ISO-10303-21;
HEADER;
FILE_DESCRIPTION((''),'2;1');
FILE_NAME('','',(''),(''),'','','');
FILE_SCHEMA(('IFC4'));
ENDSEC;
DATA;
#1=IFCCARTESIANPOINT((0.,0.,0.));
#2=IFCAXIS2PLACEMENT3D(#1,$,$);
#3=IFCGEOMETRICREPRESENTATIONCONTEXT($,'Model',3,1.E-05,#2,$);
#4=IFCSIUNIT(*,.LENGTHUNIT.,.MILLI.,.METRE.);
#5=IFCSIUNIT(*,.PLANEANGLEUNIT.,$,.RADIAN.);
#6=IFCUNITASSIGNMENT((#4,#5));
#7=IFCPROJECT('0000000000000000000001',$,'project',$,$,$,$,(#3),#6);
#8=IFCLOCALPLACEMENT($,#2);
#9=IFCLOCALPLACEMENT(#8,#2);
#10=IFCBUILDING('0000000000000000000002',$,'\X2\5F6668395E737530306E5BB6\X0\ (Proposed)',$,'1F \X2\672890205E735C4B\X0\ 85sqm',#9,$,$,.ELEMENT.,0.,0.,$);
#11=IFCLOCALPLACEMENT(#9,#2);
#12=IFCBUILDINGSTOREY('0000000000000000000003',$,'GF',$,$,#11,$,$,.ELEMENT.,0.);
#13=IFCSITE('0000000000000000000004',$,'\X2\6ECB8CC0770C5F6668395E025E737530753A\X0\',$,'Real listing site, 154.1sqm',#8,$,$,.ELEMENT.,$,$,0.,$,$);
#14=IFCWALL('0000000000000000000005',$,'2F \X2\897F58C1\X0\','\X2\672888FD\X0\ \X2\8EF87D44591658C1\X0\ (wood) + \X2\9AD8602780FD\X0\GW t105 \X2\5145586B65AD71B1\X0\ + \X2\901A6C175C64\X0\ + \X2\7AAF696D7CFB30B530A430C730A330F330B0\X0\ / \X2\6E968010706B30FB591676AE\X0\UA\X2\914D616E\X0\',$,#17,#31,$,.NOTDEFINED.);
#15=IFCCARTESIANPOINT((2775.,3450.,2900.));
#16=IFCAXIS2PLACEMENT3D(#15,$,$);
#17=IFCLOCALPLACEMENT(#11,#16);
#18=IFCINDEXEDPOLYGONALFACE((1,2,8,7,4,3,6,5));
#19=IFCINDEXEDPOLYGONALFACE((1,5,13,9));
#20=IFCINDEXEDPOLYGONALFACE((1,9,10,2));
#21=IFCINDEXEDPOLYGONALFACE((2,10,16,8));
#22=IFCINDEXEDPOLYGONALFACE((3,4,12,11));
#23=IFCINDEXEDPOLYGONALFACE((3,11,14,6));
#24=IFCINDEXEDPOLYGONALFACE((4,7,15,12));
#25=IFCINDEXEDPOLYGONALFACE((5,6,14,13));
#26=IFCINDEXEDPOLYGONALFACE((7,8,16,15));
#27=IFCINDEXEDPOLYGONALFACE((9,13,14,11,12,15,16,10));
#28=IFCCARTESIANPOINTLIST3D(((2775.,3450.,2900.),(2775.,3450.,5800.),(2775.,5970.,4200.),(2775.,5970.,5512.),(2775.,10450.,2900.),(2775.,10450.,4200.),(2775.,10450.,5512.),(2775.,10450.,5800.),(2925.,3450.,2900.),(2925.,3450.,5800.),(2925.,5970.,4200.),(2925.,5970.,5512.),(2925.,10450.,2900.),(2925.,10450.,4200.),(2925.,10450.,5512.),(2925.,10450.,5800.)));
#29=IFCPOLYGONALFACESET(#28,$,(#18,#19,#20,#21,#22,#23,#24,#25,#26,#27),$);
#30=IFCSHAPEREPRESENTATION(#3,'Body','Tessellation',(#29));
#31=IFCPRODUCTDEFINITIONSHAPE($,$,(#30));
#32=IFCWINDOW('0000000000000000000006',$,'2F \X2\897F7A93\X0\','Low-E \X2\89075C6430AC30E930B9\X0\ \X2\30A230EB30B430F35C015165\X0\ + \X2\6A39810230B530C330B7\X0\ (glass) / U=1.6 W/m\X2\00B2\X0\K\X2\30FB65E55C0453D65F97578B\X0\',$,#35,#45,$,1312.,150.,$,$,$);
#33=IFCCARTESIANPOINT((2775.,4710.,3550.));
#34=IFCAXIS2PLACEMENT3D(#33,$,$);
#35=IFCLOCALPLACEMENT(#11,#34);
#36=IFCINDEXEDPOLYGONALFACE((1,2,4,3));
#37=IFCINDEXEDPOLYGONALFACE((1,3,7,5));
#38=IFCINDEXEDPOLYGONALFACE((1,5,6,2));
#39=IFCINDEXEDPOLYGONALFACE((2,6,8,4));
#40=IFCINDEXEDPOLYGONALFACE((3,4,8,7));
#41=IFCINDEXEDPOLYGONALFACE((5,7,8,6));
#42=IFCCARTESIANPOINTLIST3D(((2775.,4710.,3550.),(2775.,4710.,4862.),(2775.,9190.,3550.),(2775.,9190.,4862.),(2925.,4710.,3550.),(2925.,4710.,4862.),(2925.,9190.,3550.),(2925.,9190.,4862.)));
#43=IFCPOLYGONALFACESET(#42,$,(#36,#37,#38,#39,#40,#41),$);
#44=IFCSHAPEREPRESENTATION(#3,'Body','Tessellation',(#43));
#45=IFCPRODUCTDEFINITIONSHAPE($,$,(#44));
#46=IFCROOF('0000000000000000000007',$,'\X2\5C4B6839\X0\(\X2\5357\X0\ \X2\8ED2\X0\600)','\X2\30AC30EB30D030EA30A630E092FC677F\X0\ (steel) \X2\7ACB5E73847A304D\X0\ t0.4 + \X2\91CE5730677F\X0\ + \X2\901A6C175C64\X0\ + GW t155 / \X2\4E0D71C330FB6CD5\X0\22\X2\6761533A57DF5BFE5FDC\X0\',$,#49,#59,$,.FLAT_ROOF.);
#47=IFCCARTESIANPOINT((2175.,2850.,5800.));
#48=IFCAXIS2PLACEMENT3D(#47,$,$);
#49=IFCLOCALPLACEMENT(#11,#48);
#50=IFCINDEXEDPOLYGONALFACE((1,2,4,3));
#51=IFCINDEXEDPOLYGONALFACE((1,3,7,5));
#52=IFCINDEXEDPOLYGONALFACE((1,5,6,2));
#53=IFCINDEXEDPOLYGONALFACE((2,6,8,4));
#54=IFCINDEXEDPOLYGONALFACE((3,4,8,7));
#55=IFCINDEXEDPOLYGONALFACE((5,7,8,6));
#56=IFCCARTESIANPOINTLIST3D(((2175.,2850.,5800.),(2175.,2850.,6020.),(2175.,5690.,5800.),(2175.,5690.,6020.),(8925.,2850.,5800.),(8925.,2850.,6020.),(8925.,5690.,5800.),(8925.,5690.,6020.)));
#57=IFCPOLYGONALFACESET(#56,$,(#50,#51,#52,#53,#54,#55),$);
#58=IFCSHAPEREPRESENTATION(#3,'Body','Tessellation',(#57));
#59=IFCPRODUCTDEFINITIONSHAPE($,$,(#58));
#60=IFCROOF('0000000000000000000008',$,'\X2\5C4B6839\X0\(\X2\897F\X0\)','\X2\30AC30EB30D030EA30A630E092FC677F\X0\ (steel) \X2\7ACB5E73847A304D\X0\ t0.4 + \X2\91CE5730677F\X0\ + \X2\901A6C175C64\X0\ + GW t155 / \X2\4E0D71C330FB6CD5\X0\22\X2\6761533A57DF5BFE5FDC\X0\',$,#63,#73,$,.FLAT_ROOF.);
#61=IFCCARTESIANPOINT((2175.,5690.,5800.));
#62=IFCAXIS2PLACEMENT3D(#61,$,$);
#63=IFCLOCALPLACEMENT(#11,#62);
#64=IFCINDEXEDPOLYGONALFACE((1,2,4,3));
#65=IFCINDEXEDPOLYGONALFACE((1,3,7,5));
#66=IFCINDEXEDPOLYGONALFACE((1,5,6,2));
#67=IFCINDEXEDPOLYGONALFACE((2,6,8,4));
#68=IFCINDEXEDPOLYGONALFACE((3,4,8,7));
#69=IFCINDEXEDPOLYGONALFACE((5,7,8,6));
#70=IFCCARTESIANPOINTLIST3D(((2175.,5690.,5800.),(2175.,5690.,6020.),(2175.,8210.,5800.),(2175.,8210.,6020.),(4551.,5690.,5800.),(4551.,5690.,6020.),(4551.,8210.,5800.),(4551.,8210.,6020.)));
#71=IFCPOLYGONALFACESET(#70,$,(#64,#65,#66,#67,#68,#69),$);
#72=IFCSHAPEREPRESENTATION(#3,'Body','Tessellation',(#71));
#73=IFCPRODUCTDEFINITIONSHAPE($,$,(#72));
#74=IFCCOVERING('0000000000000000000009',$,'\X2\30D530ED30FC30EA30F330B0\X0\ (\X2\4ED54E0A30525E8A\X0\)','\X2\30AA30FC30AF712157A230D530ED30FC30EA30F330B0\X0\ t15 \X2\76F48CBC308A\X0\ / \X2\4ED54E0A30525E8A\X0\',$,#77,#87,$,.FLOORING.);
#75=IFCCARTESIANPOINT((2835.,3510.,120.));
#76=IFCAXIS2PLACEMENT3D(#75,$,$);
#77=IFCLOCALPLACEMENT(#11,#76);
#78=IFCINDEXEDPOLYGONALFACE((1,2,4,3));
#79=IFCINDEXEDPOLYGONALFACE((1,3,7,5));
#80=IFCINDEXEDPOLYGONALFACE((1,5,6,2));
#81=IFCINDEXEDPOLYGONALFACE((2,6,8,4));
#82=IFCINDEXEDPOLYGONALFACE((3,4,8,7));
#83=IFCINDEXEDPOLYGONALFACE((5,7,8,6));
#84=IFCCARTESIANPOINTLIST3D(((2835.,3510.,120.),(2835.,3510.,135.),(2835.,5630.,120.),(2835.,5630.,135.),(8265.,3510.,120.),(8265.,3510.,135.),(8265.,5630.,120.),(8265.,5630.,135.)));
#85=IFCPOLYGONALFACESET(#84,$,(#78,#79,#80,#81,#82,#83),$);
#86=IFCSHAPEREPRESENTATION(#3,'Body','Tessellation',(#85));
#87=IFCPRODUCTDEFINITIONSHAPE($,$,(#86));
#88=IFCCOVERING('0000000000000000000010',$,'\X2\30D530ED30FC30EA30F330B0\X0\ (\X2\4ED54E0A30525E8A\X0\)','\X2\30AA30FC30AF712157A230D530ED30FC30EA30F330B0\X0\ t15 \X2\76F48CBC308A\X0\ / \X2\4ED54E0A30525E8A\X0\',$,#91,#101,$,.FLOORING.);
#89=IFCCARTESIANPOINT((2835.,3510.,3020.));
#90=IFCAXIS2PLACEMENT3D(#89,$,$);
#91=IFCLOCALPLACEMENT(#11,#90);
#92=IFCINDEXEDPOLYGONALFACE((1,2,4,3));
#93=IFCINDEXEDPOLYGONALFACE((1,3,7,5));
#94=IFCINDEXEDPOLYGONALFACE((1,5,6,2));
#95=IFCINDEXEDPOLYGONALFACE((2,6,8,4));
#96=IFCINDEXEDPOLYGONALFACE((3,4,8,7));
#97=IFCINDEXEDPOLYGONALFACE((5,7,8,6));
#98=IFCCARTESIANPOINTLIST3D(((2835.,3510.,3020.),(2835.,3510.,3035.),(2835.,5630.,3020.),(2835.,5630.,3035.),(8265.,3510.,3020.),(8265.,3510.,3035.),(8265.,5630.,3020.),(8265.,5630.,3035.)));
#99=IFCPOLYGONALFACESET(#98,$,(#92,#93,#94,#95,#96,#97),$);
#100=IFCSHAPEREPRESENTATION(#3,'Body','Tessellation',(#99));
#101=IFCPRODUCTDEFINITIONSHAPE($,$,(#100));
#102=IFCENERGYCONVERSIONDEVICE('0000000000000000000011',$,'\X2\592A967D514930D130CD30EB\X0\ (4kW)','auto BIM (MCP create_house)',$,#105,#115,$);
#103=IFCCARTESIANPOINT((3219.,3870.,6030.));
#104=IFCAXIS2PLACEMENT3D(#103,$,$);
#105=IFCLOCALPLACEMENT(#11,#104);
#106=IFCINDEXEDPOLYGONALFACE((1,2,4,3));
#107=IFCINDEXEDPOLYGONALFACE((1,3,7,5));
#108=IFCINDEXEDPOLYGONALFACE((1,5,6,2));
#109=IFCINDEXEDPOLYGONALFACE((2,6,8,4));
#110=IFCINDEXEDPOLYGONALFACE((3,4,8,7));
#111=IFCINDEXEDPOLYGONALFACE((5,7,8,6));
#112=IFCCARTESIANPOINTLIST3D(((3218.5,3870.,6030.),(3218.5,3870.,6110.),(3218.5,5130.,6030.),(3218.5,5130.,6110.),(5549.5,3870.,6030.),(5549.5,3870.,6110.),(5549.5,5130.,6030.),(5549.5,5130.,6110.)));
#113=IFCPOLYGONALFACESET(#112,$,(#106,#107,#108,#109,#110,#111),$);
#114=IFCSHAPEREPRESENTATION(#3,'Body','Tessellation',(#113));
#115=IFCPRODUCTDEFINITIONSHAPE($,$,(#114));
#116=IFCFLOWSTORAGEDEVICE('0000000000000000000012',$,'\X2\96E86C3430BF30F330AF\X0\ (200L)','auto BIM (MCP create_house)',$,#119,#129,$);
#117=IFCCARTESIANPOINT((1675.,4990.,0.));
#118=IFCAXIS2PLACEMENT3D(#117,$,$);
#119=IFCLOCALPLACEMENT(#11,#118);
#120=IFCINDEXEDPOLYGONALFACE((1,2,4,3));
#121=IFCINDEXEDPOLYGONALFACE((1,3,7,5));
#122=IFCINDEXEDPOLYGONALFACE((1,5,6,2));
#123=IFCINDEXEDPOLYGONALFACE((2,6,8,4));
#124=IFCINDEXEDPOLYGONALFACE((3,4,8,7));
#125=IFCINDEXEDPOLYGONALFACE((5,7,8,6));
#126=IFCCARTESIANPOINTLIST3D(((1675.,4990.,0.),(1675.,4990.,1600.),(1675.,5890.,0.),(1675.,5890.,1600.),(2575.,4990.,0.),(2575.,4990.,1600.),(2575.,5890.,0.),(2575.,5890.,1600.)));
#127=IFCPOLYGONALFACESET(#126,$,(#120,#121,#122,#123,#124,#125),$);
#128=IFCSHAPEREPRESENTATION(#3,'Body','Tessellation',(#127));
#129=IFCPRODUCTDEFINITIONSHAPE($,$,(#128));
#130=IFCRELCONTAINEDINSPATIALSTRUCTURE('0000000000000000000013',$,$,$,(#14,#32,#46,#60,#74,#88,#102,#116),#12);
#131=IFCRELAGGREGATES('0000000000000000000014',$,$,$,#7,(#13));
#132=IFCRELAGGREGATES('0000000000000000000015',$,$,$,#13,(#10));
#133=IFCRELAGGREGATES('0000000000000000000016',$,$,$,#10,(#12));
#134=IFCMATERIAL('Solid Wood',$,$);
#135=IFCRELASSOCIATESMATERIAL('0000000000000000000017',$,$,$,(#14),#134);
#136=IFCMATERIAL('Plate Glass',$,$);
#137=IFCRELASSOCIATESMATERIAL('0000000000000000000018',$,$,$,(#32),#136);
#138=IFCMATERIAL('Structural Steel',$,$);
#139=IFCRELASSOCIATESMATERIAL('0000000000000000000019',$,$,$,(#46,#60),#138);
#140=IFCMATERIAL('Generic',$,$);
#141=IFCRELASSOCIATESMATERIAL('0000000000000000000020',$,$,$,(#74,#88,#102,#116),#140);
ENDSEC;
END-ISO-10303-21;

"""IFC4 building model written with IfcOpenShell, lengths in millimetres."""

from ifc_helpers import new_model, si_unit, frame, frame_2d, origin, place, context, project, spatial, rectangle, extrude, material, element, fill, save


model = new_model("IFC4")

# Units and contexts
model_context = context("Model", 3, precision=1e-05, world=origin())
ifc_project = project(units=[si_unit("LENGTHUNIT", "METRE", prefix="MILLI"), si_unit("PLANEANGLEUNIT", "RADIAN")], contexts=[model_context])

# Site, building, storey
site_placement = place(None, origin())
site = spatial("IfcSite", under=ifc_project, at=site_placement, Name="滋賀県彦根市平田町", ObjectType="Real listing site, 154.1sqm", CompositionType="ELEMENT", RefElevation=0.0)
building_placement = place(site_placement, origin())
building = spatial("IfcBuilding", under=site, at=building_placement, Name="彦根平田の家 (Proposed)", ObjectType="1F 木造平屋 85sqm", CompositionType="ELEMENT", ElevationOfRefHeight=0.0, ElevationOfTerrain=0.0)
storey_placement = place(building_placement, origin())
storey = spatial("IfcBuildingStorey", under=building, at=storey_placement, Name="GF", CompositionType="ELEMENT", Elevation=0.0)

# Shared definitions
ifc_material_1 = material(Name="Solid Wood")
ifc_material_2 = material(Name="Generic")

# Shared definitions
ifc_material_3 = material(Name="Plate Glass")

# Wall, opening, window
wall_1_placement = place(storey_placement, frame((2775.0, 3450.0, 2900.0)))
wall_1 = element("IfcWall", 1, at=wall_1_placement, inside=storey, material=ifc_material_1, Name="2F 西壁", Description="木製 軸組外壁 (wood) + 高性能GW t105 充填断熱 + 通気層 + 窯業系サイディング / 準耐火・外皮UA配慮", PredefinedType="NOTDEFINED", context=model_context, shape_type="SweptSolid", body=[
    extrude(rectangle(XDim=150.0, YDim=7000.0, at=frame_2d((75.0, 3500.0))), frame((2775.0, 3450.0, 2900.0)), (0.0, 0.0, 1.0), 2900.0),
])
opening_1_placement = place(storey_placement, frame((2775.0, 4710.0, 3550.0)))
opening_1 = element("IfcOpeningElement", 2, at=opening_1_placement, cuts=wall_1, PredefinedType="NOTDEFINED", context=model_context, shape_type="SweptSolid", body=[
    extrude(rectangle(XDim=150.0, YDim=4480.0, at=frame_2d((75.0, 2240.0))), frame((2775.0, 4710.0, 3550.0)), (0.0, 0.0, 1.0), 1312.0),
])
window_1_placement = place(storey_placement, frame((2775.0, 4710.0, 3550.0)))
window_1 = element("IfcWindow", 3, at=window_1_placement, inside=storey, material=ifc_material_3, Name="2F 西窓", Description="Low-E 複層ガラス アルゴン封入 + 樹脂サッシ (glass) / U=1.6 W/m²K・日射取得型", OverallHeight=1312.0, OverallWidth=150.0, context=model_context, shape_type="SweptSolid", body=[
    extrude(rectangle(XDim=150.0, YDim=4480.0, at=frame_2d((75.0, 2240.0))), frame((2775.0, 4710.0, 3550.0)), (0.0, 0.0, 1.0), 1312.0),
])
fill(opening_1, window_1)

# Roofs
ifc_material_4 = material(Name="Structural Steel")
roof_1_placement = place(storey_placement, frame((2175.0, 2850.0, 5800.0)))
element("IfcRoof", 4, at=roof_1_placement, inside=storey, material=ifc_material_4, Name="屋根(南 軒600)", Description="ガルバリウム鋼板 (steel) 立平葺き t0.4 + 野地板 + 通気層 + GW t155 / 不燃・法22条区域対応", PredefinedType="FLAT_ROOF", context=model_context, shape_type="SweptSolid", body=[
    extrude(rectangle(XDim=6750.0, YDim=2840.0, at=frame_2d((3375.0, 1420.0))), frame((2175.0, 2850.0, 5800.0)), (0.0, 0.0, 1.0), 220.0),
])
roof_2_placement = place(storey_placement, frame((2175.0, 5690.0, 5800.0)))
element("IfcRoof", 5, at=roof_2_placement, inside=storey, material=ifc_material_4, Name="屋根(西)", Description="ガルバリウム鋼板 (steel) 立平葺き t0.4 + 野地板 + 通気層 + GW t155 / 不燃・法22条区域対応", PredefinedType="FLAT_ROOF", context=model_context, shape_type="SweptSolid", body=[
    extrude(rectangle(XDim=2376.0, YDim=2520.0, at=frame_2d((1188.0, 1260.0))), frame((2175.0, 5690.0, 5800.0)), (0.0, 0.0, 1.0), 220.0),
])

# Coverings
covering_1_placement = place(storey_placement, frame((2835.0, 3510.0, 120.0)))
element("IfcCovering", 6, at=covering_1_placement, inside=storey, material=ifc_material_2, Name="フローリング (仕上げ床)", Description="オーク無垢フローリング t15 直貼り / 仕上げ床", PredefinedType="FLOORING", context=model_context, shape_type="SweptSolid", body=[
    extrude(rectangle(XDim=5430.0, YDim=2120.0, at=frame_2d((2715.0, 1060.0))), frame((2835.0, 3510.0, 120.0)), (0.0, 0.0, 1.0), 15.0),
])
covering_2_placement = place(storey_placement, frame((2835.0, 3510.0, 3020.0)))
element("IfcCovering", 7, at=covering_2_placement, inside=storey, material=ifc_material_2, Name="フローリング (仕上げ床)", Description="オーク無垢フローリング t15 直貼り / 仕上げ床", PredefinedType="FLOORING", context=model_context, shape_type="SweptSolid", body=[
    extrude(rectangle(XDim=5430.0, YDim=2120.0, at=frame_2d((2715.0, 1060.0))), frame((2835.0, 3510.0, 3020.0)), (0.0, 0.0, 1.0), 15.0),
])

# Energy conversion device
energy_conversion_device_placement = place(storey_placement, frame((3219.0, 3870.0, 6030.0)))
element("IfcEnergyConversionDevice", 8, at=energy_conversion_device_placement, inside=storey, material=ifc_material_2, Name="太陽光パネル (4kW)", Description="auto BIM (MCP create_house)", context=model_context, shape_type="SweptSolid", body=[
    extrude(rectangle(XDim=2331.0, YDim=1260.0, at=frame_2d((1165.0, 630.0))), frame((3219.0, 3870.0, 6030.0)), (0.0, 0.0, 1.0), 80.0),
])

# Flow storage device
flow_storage_device_placement = place(storey_placement, frame((1675.0, 4990.0, 0.0)))
element("IfcFlowStorageDevice", 9, at=flow_storage_device_placement, inside=storey, material=ifc_material_2, Name="雨水タンク (200L)", Description="auto BIM (MCP create_house)", context=model_context, shape_type="SweptSolid", body=[
    extrude(rectangle(XDim=900.0, YDim=900.0, at=frame_2d((450.0, 450.0))), frame((1675.0, 4990.0, 0.0)), (0.0, 0.0, 1.0), 1600.0),
])

save(model, "model.ifc")
